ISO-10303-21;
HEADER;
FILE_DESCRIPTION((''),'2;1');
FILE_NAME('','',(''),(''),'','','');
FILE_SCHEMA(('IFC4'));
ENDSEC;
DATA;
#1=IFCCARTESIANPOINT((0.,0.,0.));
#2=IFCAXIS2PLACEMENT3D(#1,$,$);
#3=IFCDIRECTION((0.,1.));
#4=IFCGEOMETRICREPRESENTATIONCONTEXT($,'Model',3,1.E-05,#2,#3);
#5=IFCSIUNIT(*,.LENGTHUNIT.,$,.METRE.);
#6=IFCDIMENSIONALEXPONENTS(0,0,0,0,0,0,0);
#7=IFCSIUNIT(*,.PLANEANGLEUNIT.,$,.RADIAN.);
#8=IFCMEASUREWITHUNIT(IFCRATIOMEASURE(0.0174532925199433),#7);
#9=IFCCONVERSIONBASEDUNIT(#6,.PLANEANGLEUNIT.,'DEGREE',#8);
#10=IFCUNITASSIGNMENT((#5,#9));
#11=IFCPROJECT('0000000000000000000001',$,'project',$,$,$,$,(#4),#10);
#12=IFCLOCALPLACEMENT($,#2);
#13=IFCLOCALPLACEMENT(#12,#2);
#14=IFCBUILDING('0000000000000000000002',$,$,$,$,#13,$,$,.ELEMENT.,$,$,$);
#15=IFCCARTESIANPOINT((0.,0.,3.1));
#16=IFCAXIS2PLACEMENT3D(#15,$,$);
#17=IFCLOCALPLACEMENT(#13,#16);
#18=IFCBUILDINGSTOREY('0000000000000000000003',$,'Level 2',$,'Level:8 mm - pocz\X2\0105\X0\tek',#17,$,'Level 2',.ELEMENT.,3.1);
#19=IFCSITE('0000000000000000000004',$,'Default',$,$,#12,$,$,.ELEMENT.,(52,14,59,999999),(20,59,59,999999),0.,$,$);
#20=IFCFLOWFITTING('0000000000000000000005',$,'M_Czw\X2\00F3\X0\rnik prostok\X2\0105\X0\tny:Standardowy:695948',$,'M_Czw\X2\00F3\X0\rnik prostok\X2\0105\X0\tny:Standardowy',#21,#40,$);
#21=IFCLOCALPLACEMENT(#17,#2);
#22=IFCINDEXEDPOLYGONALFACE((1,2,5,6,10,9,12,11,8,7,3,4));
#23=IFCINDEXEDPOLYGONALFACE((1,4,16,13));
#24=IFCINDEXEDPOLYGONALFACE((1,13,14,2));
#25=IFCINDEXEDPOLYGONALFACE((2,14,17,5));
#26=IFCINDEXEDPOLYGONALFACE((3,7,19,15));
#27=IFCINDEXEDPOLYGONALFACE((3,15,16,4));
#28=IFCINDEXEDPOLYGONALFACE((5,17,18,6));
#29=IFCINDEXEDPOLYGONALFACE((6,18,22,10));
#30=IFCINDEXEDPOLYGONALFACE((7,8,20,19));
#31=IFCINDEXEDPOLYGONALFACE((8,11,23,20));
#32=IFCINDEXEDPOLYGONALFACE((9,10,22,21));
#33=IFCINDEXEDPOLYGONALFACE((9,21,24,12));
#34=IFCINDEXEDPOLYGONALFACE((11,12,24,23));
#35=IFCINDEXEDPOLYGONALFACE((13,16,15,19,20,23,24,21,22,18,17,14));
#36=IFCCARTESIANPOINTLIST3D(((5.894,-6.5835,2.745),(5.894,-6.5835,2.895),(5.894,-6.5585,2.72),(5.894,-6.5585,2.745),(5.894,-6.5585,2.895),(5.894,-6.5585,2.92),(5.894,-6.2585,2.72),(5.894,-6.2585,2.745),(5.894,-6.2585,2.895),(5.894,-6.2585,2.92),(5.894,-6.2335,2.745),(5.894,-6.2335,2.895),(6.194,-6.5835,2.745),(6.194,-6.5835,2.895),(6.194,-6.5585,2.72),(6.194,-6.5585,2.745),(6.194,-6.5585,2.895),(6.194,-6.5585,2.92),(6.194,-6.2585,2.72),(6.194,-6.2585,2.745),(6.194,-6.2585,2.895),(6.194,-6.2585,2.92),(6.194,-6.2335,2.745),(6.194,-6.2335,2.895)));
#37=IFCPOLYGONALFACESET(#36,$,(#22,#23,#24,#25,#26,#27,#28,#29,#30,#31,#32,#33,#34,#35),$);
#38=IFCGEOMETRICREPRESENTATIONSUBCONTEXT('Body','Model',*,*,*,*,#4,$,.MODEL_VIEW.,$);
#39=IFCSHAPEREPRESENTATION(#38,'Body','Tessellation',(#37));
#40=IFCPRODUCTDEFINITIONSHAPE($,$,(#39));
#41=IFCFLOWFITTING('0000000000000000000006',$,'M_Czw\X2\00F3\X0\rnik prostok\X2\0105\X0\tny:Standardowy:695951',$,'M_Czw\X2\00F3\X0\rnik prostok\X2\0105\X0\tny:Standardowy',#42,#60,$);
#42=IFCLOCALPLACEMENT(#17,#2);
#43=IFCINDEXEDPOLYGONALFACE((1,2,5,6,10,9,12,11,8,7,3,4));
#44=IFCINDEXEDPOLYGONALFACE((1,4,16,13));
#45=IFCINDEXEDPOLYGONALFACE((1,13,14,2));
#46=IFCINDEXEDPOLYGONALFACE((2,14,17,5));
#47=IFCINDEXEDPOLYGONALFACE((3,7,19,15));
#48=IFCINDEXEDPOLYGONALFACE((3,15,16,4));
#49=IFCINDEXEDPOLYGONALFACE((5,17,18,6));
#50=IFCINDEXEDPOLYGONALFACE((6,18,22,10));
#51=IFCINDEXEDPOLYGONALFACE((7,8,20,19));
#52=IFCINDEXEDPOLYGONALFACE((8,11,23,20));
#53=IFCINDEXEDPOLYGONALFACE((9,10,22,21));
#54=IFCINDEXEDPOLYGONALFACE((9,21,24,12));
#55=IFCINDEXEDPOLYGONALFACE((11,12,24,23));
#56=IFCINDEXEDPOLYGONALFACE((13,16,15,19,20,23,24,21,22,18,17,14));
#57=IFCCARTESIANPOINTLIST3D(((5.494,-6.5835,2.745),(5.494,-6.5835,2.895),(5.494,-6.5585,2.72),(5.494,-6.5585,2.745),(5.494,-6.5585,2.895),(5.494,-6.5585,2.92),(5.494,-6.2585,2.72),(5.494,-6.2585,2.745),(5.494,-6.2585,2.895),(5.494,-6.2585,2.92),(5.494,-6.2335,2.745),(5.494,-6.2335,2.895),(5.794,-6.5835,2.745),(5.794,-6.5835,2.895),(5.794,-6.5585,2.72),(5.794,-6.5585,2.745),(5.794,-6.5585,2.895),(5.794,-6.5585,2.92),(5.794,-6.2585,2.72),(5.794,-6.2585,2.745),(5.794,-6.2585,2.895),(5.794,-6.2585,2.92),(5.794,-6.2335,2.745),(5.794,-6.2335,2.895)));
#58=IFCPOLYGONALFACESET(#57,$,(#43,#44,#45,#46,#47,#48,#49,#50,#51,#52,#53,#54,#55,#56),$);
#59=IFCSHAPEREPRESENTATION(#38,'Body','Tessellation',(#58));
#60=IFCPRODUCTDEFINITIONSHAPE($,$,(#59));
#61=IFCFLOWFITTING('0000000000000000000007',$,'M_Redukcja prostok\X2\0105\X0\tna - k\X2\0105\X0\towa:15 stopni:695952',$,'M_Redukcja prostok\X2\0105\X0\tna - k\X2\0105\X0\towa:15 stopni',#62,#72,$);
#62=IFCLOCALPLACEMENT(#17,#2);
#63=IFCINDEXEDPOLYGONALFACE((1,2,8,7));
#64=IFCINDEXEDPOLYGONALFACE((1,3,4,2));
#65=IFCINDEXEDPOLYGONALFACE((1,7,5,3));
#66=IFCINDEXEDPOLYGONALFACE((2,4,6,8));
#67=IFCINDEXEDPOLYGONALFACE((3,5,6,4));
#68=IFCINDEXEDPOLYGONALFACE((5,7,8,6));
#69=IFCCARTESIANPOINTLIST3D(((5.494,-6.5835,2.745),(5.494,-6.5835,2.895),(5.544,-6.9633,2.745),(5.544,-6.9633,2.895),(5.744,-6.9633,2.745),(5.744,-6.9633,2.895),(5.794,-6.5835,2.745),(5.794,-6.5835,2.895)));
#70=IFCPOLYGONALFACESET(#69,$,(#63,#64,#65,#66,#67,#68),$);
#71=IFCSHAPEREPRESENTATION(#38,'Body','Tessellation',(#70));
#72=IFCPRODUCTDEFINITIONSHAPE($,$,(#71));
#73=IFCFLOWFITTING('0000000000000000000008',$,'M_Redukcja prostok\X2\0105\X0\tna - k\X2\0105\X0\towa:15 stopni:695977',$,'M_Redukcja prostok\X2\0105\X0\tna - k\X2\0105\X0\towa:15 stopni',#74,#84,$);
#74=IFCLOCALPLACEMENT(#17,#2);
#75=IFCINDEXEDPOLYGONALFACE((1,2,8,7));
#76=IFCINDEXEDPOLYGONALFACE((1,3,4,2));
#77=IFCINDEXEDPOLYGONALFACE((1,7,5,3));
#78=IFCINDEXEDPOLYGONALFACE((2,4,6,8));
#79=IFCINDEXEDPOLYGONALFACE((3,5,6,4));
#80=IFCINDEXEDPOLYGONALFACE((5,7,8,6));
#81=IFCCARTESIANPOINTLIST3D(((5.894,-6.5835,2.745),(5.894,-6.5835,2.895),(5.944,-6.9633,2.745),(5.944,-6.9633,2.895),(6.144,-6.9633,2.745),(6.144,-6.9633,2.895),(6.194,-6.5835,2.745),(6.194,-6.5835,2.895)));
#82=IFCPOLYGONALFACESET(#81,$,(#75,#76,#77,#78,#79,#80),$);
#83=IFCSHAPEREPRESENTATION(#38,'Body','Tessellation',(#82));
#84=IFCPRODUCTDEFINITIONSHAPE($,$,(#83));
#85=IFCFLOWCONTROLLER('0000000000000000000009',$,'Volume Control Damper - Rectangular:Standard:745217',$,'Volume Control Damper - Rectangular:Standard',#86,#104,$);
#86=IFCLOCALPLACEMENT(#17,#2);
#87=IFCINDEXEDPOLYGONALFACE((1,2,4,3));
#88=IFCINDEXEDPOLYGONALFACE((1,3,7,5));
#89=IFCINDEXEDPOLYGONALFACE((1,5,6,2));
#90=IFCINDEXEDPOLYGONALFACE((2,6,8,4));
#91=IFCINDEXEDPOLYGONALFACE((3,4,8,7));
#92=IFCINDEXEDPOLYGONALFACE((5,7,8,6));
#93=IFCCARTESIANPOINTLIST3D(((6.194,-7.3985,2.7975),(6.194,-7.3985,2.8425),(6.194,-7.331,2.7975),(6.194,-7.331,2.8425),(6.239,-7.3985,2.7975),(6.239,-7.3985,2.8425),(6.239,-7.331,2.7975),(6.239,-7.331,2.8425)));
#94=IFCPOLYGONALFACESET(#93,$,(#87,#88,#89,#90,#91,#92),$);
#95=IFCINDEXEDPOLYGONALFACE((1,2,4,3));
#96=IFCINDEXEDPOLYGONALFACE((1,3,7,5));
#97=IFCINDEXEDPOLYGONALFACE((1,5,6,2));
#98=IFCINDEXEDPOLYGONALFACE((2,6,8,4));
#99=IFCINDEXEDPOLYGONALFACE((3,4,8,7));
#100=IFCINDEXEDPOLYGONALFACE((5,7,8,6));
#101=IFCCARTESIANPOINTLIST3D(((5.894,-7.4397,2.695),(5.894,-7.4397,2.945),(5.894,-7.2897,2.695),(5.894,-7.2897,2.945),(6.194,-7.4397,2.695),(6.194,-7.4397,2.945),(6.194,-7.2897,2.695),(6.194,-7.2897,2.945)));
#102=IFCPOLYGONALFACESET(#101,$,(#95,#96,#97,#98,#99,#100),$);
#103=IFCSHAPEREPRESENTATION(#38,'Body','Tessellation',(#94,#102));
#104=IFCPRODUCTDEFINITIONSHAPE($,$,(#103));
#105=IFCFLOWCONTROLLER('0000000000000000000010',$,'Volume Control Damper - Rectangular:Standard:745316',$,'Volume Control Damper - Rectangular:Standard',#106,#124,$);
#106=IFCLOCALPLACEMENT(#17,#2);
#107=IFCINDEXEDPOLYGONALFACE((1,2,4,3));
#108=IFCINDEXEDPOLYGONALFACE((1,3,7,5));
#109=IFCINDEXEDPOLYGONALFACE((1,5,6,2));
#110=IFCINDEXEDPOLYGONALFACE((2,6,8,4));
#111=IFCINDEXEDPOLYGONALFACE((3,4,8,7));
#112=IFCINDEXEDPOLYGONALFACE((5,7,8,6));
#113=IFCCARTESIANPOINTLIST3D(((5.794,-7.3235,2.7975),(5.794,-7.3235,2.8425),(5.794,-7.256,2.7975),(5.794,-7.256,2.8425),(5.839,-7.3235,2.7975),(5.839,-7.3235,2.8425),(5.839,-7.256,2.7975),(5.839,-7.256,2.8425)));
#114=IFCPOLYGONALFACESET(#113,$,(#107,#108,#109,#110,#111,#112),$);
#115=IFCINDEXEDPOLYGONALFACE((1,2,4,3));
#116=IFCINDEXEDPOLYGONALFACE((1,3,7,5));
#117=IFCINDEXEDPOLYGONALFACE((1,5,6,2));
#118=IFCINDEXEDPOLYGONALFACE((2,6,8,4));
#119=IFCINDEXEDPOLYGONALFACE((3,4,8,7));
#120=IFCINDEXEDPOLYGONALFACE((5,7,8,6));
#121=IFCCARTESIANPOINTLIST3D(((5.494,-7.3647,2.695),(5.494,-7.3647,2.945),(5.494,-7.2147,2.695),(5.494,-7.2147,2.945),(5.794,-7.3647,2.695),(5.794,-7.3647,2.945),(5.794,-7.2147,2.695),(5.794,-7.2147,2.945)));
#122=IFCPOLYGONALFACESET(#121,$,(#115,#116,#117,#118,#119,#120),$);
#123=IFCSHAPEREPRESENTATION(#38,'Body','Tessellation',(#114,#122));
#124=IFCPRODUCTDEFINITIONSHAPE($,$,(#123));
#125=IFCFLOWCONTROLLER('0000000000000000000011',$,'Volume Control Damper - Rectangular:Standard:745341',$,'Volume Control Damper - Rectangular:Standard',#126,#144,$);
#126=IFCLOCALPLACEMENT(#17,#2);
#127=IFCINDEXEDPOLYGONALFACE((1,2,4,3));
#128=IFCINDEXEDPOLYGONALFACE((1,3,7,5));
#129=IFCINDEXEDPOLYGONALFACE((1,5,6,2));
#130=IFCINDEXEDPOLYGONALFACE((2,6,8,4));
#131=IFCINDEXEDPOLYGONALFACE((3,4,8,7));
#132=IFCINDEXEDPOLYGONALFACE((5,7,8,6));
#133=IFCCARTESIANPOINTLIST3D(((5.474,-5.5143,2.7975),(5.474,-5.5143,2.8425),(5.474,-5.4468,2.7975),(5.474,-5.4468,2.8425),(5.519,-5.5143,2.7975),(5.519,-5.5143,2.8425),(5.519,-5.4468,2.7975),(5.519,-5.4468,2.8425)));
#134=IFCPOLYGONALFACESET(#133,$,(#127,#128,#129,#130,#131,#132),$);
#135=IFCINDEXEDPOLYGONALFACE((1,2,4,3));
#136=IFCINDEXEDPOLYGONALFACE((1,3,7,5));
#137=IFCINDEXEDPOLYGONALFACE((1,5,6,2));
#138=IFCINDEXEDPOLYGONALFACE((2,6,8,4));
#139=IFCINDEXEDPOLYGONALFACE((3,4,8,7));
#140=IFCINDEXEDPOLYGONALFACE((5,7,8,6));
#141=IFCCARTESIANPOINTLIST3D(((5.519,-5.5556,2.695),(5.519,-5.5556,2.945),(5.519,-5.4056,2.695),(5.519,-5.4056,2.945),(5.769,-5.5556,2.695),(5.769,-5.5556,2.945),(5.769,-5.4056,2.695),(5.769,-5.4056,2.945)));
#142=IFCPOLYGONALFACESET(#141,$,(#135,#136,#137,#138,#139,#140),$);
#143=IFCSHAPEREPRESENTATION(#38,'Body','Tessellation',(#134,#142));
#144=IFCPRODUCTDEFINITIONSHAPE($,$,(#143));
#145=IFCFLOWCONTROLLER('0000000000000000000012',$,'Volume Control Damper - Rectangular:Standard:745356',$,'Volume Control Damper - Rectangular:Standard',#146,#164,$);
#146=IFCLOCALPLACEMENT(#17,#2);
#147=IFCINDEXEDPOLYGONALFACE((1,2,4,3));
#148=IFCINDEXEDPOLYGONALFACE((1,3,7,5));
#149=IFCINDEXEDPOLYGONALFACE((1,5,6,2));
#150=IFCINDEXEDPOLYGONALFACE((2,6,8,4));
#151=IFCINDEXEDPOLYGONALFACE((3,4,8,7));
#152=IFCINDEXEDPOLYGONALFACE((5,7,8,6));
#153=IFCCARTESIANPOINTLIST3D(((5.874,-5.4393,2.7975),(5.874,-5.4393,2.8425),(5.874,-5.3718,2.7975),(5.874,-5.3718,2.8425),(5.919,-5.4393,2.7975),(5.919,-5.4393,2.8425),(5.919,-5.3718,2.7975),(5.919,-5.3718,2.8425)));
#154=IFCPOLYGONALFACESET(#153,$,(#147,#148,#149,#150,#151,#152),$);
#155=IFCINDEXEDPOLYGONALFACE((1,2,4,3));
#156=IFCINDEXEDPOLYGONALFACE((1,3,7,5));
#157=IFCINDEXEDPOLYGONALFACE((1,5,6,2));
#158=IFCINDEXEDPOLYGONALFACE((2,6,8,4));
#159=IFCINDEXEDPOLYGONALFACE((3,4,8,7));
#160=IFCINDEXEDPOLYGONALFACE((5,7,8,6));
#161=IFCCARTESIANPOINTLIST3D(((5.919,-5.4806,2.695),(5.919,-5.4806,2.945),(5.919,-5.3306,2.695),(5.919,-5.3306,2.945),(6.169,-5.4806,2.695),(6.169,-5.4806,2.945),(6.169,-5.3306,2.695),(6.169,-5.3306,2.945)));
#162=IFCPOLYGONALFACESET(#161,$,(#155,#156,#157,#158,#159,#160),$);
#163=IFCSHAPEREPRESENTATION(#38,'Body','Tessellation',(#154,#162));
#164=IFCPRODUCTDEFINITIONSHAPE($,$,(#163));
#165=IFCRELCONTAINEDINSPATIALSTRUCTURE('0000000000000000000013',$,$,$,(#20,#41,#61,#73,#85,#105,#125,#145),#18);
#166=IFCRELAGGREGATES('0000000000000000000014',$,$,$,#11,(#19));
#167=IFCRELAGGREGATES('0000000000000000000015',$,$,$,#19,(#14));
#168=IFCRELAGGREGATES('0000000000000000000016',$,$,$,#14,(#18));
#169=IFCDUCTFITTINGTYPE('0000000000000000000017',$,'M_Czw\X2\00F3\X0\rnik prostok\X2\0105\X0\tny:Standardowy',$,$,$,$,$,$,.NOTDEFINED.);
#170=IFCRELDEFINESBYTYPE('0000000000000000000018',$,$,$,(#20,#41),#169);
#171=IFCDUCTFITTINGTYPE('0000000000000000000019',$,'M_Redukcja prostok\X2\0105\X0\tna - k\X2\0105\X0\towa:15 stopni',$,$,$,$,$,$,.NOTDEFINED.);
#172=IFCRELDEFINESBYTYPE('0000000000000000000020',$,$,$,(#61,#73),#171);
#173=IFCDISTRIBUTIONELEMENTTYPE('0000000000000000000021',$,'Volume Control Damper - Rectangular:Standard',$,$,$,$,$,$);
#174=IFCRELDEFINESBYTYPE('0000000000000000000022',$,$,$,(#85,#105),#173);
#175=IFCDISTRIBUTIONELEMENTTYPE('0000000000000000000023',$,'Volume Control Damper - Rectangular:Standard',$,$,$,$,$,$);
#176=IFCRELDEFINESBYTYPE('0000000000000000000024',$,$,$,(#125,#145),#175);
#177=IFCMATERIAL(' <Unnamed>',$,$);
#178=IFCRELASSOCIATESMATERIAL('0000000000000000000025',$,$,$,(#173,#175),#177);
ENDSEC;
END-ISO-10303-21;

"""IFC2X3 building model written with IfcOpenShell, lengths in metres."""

from ifc_helpers import new_model, entity, si_unit, converted_unit, direction, frame, frame_2d, origin, origin_2d_with_axis, place, context, subcontext, project, spatial, polyline, rectangle, outline, extrude, source, transform, mapped, material, type_object, type_shapes, element, save


model = new_model("IFC2X3")

# Units and contexts
model_context = context("Model", 3, precision=1e-05, world=origin(), true_north=direction((0.0, 1.0)))
body_context = subcontext(model_context, "Body", "Model", "MODEL_VIEW")
ifc_project = project(units=[si_unit("LENGTHUNIT", "METRE"), converted_unit("PLANEANGLEUNIT", "DEGREE", entity("IfcRatioMeasure", 0.0174532925199433), si_unit("PLANEANGLEUNIT", "RADIAN"), dimensions=[0, 0, 0, 0, 0, 0, 0])], contexts=[model_context])

# Site, building, storey
site_placement = place(None, origin())
site = spatial("IfcSite", under=ifc_project, at=site_placement, Name="Default", CompositionType="ELEMENT", RefLatitude=(52, 14, 59, 999999), RefLongitude=(20, 59, 59, 999999), RefElevation=0.0)
building_placement = place(site_placement, origin())
building = spatial("IfcBuilding", under=site, at=building_placement, CompositionType="ELEMENT")
storey_placement = place(building_placement, frame((0.0, 0.0, 3.1)))
storey = spatial("IfcBuildingStorey", under=building, at=storey_placement, Name="Level 2", ObjectType="Level:8 mm - początek", LongName="Level 2", CompositionType="ELEMENT", Elevation=3.1)

# Flow fittings
duct_fitting_type_1 = type_object("IfcDuctFittingType", Name="M_Czwórnik prostokątny:Standardowy", PredefinedType="NOTDEFINED")
shared_shape_1 = source(origin(), body_context, "Body", "SweptSolid", [
    extrude(outline(polyline([(-0.175, 0.075), (-0.175, -0.075), (-0.15, -0.075), (-0.15, -0.1), (0.15, -0.1), (0.15, -0.075), (0.175, -0.075), (0.175, 0.075), (0.15, 0.075), (0.15, 0.1), (-0.15, 0.1), (-0.15, 0.075), (-0.175, 0.075)])), frame((0.0, 0.0, -0.15), z_axis=(0.0, 0.0, -1.0), x_axis=(0.0, 1.0, 0.0)), (0.0, 0.0, -1.0), 0.3),
])
type_shapes(duct_fitting_type_1, [shared_shape_1])
for number, where, z_axis, x_axis, name in (
    (1, (6.044, -6.4085, 2.82), (-1.0, 0.0, 0.0), (0.0, 0.0, 1.0), "M_Czwórnik prostokątny:Standardowy:695948"),
    (2, (5.644, -6.4085, 2.82), (-1.0, 0.0, 0.0), (0.0, 0.0, 1.0), "M_Czwórnik prostokątny:Standardowy:695951"),
):
    element("IfcFlowFitting", number, at=place(storey_placement, frame(where, z_axis=z_axis, x_axis=x_axis)), inside=storey, type_object=duct_fitting_type_1, Name=name, ObjectType="M_Czwórnik prostokątny:Standardowy", context=body_context, shape_type="MappedRepresentation", body=[
        mapped(shared_shape_1, transform((0.0, 0.0, 0.0), scale=1.0)),
    ])
duct_fitting_type_2 = type_object("IfcDuctFittingType", Name="M_Redukcja prostokątna - kątowa:15 stopni", PredefinedType="NOTDEFINED")
shared_shape_2 = source(origin(), body_context, "Body", "SweptSolid", [
    extrude(outline(polyline([(-0.15, -0.1899), (0.15, -0.1899), (0.1, 0.1899), (-0.1, 0.1899), (-0.15, -0.1899)])), frame((0.1899, 0.0, -0.075), z_axis=(0.0, 0.0, 1.0), x_axis=(0.0, -1.0, 0.0)), (0.0, 0.0, 1.0), 0.15),
])
type_shapes(duct_fitting_type_2, [shared_shape_2])
for number, where, z_axis, x_axis, name in (
    (3, (5.644, -6.5835, 2.82), (0.0, 0.0, 1.0), (0.0, -1.0, 0.0), "M_Redukcja prostokątna - kątowa:15 stopni:695952"),
    (4, (6.044, -6.5835, 2.82), (0.0, 0.0, 1.0), (0.0, -1.0, 0.0), "M_Redukcja prostokątna - kątowa:15 stopni:695977"),
):
    element("IfcFlowFitting", number, at=place(storey_placement, frame(where, z_axis=z_axis, x_axis=x_axis)), inside=storey, type_object=duct_fitting_type_2, Name=name, ObjectType="M_Redukcja prostokątna - kątowa:15 stopni", context=body_context, shape_type="MappedRepresentation", body=[
        mapped(shared_shape_2, transform((0.0, 0.0, 0.0), scale=1.0)),
    ])

# Flow controllers
ifc_material = material(Name=" <Unnamed>")
distribution_element_type_1 = type_object("IfcDistributionElementType", Name="Volume Control Damper - Rectangular:Standard", material=ifc_material)
shared_shape_3 = source(origin(), body_context, "Body", "SweptSolid", [
    extrude(rectangle(XDim=0.0675, YDim=0.045, at=frame_2d((0.0, 0.0), x_axis=(1.0, 0.0))), frame((0.0, 0.1725, -0.0225), z_axis=(0.0, 0.0, 1.0), x_axis=(-1.0, 0.0, 0.0)), (0.0, 0.0, 1.0), 0.045),
    extrude(rectangle(XDim=0.15, YDim=0.3, at=origin_2d_with_axis()), frame((0.0, 0.0, -0.125), z_axis=(0.0, 0.0, 1.0), x_axis=(-1.0, 0.0, 0.0)), (0.0, 0.0, 1.0), 0.25),
])
type_shapes(distribution_element_type_1, [shared_shape_3])
for number, where, z_axis, x_axis, name in (
    (5, (6.044, -7.3647, 2.82), (0.0, 0.0, -1.0), (0.0, 1.0, 0.0), "Volume Control Damper - Rectangular:Standard:745217"),
    (6, (5.644, -7.2897, 2.82), (0.0, 0.0, -1.0), (0.0, 1.0, 0.0), "Volume Control Damper - Rectangular:Standard:745316"),
):
    element("IfcFlowController", number, at=place(storey_placement, frame(where, z_axis=z_axis, x_axis=x_axis)), inside=storey, type_object=distribution_element_type_1, Name=name, ObjectType="Volume Control Damper - Rectangular:Standard", context=body_context, shape_type="MappedRepresentation", body=[
        mapped(shared_shape_3, transform((0.0, 0.0, 0.0), scale=1.0)),
    ])
distribution_element_type_2 = type_object("IfcDistributionElementType", Name="Volume Control Damper - Rectangular:Standard", material=ifc_material)
shared_shape_4 = source(origin(), body_context, "Body", "SweptSolid", [
    extrude(rectangle(XDim=0.0675, YDim=0.045, at=origin_2d_with_axis()), frame((0.0, 0.1475, -0.0225), z_axis=(0.0, 0.0, 1.0), x_axis=(-1.0, 0.0, 0.0)), (0.0, 0.0, 1.0), 0.045),
    extrude(rectangle(XDim=0.15, YDim=0.25, at=origin_2d_with_axis()), frame((0.0, 0.0, -0.125), z_axis=(0.0, 0.0, 1.0), x_axis=(-1.0, 0.0, 0.0)), (0.0, 0.0, 1.0), 0.25),
])
type_shapes(distribution_element_type_2, [shared_shape_4])
for number, where, z_axis, x_axis, name in (
    (7, (5.644, -5.4806, 2.82), (0.0, 0.0, -1.0), (0.0, -1.0, 0.0), "Volume Control Damper - Rectangular:Standard:745341"),
    (8, (6.044, -5.4056, 2.82), (0.0, 0.0, -1.0), (0.0, -1.0, 0.0), "Volume Control Damper - Rectangular:Standard:745356"),
):
    element("IfcFlowController", number, at=place(storey_placement, frame(where, z_axis=z_axis, x_axis=x_axis)), inside=storey, type_object=distribution_element_type_2, Name=name, ObjectType="Volume Control Damper - Rectangular:Standard", context=body_context, shape_type="MappedRepresentation", body=[
        mapped(shared_shape_4, transform((0.0, 0.0, 0.0), scale=1.0)),
    ])

save(model, "model.ifc")
